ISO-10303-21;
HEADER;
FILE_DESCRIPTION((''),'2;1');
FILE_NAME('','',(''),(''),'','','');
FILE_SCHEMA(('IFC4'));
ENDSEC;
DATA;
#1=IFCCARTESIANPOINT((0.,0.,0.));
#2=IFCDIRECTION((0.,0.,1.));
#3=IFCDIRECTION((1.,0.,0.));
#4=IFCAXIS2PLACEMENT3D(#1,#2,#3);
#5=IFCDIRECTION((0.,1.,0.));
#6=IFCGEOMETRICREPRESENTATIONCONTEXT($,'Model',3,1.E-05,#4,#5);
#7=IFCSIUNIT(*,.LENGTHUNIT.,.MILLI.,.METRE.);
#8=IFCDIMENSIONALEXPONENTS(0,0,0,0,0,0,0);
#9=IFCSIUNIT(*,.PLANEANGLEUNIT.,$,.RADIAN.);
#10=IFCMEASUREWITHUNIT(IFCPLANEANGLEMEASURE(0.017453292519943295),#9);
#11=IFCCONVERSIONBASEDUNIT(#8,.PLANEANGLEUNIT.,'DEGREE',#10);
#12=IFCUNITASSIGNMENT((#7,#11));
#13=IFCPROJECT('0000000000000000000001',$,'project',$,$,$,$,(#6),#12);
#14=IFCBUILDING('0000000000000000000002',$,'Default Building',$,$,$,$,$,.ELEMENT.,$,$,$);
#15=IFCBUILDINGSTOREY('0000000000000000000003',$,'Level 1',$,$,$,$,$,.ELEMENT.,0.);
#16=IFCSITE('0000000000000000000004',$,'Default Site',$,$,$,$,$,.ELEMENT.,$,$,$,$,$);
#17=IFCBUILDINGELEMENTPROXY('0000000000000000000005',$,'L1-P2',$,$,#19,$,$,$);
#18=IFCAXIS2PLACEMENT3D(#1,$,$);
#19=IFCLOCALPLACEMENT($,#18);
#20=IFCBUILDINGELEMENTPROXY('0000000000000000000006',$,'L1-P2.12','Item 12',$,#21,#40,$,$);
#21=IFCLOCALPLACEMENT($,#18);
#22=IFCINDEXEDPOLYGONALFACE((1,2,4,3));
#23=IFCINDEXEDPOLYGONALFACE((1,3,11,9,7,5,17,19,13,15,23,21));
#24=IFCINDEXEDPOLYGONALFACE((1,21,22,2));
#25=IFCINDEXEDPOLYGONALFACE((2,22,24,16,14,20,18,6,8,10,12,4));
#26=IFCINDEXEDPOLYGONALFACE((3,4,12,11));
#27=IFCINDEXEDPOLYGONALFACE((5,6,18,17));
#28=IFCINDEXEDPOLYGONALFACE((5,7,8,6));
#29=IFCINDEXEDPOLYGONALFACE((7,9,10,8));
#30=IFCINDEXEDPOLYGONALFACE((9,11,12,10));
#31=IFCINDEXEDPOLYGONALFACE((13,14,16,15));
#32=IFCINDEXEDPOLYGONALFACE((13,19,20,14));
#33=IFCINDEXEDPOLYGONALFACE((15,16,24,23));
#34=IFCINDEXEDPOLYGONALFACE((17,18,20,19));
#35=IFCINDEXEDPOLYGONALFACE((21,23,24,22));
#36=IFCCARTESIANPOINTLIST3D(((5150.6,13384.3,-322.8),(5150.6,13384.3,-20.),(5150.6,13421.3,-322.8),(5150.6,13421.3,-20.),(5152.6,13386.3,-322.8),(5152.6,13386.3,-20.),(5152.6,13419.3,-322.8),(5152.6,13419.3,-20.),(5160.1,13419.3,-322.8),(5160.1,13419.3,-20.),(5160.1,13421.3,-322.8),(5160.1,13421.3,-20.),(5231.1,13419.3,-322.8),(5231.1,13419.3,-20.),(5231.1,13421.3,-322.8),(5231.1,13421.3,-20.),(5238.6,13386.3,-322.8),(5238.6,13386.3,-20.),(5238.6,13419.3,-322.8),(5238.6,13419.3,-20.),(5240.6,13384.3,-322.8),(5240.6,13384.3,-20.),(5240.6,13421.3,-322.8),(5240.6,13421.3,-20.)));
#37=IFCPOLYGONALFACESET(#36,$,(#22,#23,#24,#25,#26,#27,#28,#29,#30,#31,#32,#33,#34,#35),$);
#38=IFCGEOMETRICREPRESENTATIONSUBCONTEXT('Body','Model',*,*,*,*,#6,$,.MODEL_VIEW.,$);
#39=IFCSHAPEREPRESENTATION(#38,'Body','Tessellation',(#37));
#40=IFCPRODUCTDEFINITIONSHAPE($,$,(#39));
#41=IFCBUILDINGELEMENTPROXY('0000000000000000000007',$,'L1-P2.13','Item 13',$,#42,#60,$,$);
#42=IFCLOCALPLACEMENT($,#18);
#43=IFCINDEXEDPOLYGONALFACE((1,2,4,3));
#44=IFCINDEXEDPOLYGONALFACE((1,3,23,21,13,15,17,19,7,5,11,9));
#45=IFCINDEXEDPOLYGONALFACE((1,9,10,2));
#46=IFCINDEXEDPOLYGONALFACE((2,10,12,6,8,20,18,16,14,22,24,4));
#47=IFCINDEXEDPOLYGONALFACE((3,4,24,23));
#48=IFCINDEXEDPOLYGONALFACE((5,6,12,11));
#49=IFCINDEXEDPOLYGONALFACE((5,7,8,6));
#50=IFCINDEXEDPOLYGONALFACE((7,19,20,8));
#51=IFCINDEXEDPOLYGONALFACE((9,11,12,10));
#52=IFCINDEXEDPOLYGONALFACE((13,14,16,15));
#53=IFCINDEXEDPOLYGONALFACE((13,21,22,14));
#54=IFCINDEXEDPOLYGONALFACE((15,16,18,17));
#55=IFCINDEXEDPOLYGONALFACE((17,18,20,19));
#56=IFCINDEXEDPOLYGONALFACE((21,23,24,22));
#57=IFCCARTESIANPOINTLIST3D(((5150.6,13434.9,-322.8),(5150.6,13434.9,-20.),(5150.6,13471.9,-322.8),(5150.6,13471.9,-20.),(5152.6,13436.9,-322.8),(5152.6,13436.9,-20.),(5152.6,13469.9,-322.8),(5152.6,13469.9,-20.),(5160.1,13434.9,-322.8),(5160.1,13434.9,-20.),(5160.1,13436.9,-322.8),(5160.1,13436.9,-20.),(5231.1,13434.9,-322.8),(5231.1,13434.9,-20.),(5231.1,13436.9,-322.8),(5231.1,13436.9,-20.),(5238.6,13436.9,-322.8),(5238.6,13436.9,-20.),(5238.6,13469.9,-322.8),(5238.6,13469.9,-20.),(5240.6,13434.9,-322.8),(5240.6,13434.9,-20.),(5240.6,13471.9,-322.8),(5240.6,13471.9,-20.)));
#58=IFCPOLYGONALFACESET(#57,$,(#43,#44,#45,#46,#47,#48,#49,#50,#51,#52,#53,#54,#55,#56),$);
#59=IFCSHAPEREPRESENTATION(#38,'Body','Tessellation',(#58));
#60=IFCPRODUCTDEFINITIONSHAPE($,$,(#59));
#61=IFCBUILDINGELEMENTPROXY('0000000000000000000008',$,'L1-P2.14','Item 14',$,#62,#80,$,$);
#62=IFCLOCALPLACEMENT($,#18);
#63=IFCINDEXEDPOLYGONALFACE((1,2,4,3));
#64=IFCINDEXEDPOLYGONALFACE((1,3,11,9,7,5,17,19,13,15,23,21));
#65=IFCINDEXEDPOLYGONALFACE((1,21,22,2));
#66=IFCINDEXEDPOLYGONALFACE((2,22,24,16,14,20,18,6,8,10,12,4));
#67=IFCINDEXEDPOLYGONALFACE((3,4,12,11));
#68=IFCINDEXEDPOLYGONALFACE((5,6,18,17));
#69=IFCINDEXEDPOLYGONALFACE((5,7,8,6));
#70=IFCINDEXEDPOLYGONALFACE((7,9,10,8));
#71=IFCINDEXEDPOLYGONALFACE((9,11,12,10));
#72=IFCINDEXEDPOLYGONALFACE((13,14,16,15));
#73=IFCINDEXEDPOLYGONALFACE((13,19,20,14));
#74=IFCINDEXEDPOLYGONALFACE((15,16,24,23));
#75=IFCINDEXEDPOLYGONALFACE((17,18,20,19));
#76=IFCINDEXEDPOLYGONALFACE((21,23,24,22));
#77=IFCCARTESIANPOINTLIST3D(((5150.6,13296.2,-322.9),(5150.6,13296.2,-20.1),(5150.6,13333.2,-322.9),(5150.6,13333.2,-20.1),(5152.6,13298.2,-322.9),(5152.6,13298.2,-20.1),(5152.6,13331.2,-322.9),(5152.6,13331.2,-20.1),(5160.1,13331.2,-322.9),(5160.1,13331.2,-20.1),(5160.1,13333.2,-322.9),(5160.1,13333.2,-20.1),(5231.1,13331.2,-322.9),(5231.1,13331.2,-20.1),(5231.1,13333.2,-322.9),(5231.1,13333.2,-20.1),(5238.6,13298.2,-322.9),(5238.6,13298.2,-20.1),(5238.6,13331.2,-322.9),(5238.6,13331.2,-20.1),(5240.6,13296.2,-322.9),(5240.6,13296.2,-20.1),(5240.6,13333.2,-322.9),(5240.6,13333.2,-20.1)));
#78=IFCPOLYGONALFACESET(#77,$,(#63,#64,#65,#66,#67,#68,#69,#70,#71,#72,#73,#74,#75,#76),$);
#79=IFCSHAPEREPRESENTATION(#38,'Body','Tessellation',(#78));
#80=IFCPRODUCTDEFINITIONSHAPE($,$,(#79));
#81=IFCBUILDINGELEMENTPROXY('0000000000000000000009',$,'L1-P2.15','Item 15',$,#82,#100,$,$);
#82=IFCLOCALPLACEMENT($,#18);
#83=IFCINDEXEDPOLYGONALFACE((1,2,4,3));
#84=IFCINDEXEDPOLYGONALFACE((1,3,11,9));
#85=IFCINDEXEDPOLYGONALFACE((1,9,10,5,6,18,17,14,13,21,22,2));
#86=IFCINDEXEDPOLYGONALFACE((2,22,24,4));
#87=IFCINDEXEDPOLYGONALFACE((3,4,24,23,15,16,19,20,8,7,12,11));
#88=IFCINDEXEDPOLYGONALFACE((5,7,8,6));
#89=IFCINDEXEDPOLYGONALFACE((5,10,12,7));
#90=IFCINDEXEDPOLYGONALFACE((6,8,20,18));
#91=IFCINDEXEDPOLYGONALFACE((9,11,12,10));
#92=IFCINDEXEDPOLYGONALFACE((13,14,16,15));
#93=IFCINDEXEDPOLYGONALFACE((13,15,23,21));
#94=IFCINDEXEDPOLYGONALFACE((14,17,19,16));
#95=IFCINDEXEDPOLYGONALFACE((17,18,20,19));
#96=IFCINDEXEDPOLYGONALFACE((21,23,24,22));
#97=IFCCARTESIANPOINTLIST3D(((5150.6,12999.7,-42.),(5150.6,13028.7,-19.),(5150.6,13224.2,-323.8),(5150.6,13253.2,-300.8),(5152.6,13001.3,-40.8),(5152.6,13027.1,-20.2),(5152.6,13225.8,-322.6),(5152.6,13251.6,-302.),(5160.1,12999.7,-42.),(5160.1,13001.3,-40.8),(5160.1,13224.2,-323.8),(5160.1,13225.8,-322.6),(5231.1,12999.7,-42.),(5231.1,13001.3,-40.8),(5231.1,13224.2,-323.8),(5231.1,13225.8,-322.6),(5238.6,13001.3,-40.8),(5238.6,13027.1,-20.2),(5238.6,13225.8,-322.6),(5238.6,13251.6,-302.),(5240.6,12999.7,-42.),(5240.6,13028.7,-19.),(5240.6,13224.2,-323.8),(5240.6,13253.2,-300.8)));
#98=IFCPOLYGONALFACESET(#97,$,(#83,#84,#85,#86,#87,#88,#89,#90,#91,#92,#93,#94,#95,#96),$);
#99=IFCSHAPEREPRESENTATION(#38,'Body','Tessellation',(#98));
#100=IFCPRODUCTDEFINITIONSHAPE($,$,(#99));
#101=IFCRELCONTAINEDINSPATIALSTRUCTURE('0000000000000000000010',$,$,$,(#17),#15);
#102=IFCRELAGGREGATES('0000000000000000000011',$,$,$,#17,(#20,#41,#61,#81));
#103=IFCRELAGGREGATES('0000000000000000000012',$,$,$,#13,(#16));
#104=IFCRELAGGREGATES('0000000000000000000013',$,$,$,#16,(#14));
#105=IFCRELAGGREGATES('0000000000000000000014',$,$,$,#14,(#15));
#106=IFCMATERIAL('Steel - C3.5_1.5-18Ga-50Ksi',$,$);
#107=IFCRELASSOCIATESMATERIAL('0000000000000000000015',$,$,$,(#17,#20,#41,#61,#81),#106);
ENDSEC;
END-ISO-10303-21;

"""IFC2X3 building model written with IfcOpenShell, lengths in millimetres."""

from ifc_helpers import new_model, entity, si_unit, converted_unit, direction, frame, origin, origin_with_axes, origin_2d_with_axis, place, context, subcontext, project, spatial, c_section, extrude, material, element, aggregate, save


model = new_model("IFC2X3")

# Units and contexts
model_context = context("Model", 3, precision=1e-05, world=origin_with_axes(), true_north=direction((0.0, 1.0, 0.0)))
body_context = subcontext(model_context, "Body", "Model", "MODEL_VIEW")
ifc_project = project(units=[si_unit("LENGTHUNIT", "METRE", prefix="MILLI"), converted_unit("PLANEANGLEUNIT", "DEGREE", entity("IfcPlaneAngleMeasure", 0.017453292519943295), si_unit("PLANEANGLEUNIT", "RADIAN"), dimensions=[0, 0, 0, 0, 0, 0, 0])], contexts=[model_context])

# Site, building, storey
site = spatial("IfcSite", under=ifc_project, Name="Default Site", CompositionType="ELEMENT")
building = spatial("IfcBuilding", under=site, Name="Default Building", CompositionType="ELEMENT")
storey = spatial("IfcBuildingStorey", under=building, Name="Level 1", CompositionType="ELEMENT", Elevation=0.0)

# Shared definitions
ifc_material_1 = material(Name="Steel - C3.5_1.5-18Ga-50Ksi")

# Building element proxies
proxy_1 = element("IfcBuildingElementProxy", 1, inside=storey, material=ifc_material_1, Name="L1-P2")
proxy_2_placement = place(None, frame((5195.6, 13402.8, -20.0), z_axis=(0.0, 0.0, -1.0), x_axis=(0.0, 37.0, 0.0)))
proxy_2 = element("IfcBuildingElementProxy", 2, at=proxy_2_placement, material=ifc_material_1, Name="L1-P2.12", Description="Item 12", context=body_context, shape_type="SweptSolid", body=[
    extrude(c_section(Depth=90.0, Width=37.0, WallThickness=2.0, Girth=9.5, at=origin_2d_with_axis()), origin(), (0.0, 0.0, 1.0), 302.8),
])
proxy_3_placement = place(None, frame((5195.6, 13453.4, -322.8), z_axis=(0.0, 0.0, 1.0), x_axis=(0.0, -37.0, 0.0)))
proxy_3 = element("IfcBuildingElementProxy", 3, at=proxy_3_placement, material=ifc_material_1, Name="L1-P2.13", Description="Item 13", context=body_context, shape_type="SweptSolid", body=[
    extrude(c_section(Depth=90.0, Width=37.0, WallThickness=2.0, Girth=9.5, at=origin_2d_with_axis()), origin(), (0.0, 0.0, 1.0), 302.8),
])
proxy_4_placement = place(None, frame((5195.6, 13314.7, -20.1), z_axis=(0.0, 0.0, -1.0), x_axis=(0.0, 37.0, 0.0)))
proxy_4 = element("IfcBuildingElementProxy", 4, at=proxy_4_placement, material=ifc_material_1, Name="L1-P2.14", Description="Item 14", context=body_context, shape_type="SweptSolid", body=[
    extrude(c_section(Depth=90.0, Width=37.0, WallThickness=2.0, Girth=9.5, at=origin_2d_with_axis()), origin(), (0.0, 0.0, 1.0), 302.8),
])
proxy_5_placement = place(None, frame((5195.6, 13238.7, -312.3), z_axis=(0.0, -0.623, 0.782), x_axis=(0.0, -28.929, -23.068)))
proxy_5 = element("IfcBuildingElementProxy", 5, at=proxy_5_placement, material=ifc_material_1, Name="L1-P2.15", Description="Item 15", context=body_context, shape_type="SweptSolid", body=[
    extrude(c_section(Depth=90.0, Width=37.0, WallThickness=2.0, Girth=9.5, at=origin_2d_with_axis()), origin(), (0.0, 0.0, 1.0), 360.3),
])
aggregate(proxy_1, [proxy_2, proxy_3, proxy_4, proxy_5])

save(model, "model.ifc")
